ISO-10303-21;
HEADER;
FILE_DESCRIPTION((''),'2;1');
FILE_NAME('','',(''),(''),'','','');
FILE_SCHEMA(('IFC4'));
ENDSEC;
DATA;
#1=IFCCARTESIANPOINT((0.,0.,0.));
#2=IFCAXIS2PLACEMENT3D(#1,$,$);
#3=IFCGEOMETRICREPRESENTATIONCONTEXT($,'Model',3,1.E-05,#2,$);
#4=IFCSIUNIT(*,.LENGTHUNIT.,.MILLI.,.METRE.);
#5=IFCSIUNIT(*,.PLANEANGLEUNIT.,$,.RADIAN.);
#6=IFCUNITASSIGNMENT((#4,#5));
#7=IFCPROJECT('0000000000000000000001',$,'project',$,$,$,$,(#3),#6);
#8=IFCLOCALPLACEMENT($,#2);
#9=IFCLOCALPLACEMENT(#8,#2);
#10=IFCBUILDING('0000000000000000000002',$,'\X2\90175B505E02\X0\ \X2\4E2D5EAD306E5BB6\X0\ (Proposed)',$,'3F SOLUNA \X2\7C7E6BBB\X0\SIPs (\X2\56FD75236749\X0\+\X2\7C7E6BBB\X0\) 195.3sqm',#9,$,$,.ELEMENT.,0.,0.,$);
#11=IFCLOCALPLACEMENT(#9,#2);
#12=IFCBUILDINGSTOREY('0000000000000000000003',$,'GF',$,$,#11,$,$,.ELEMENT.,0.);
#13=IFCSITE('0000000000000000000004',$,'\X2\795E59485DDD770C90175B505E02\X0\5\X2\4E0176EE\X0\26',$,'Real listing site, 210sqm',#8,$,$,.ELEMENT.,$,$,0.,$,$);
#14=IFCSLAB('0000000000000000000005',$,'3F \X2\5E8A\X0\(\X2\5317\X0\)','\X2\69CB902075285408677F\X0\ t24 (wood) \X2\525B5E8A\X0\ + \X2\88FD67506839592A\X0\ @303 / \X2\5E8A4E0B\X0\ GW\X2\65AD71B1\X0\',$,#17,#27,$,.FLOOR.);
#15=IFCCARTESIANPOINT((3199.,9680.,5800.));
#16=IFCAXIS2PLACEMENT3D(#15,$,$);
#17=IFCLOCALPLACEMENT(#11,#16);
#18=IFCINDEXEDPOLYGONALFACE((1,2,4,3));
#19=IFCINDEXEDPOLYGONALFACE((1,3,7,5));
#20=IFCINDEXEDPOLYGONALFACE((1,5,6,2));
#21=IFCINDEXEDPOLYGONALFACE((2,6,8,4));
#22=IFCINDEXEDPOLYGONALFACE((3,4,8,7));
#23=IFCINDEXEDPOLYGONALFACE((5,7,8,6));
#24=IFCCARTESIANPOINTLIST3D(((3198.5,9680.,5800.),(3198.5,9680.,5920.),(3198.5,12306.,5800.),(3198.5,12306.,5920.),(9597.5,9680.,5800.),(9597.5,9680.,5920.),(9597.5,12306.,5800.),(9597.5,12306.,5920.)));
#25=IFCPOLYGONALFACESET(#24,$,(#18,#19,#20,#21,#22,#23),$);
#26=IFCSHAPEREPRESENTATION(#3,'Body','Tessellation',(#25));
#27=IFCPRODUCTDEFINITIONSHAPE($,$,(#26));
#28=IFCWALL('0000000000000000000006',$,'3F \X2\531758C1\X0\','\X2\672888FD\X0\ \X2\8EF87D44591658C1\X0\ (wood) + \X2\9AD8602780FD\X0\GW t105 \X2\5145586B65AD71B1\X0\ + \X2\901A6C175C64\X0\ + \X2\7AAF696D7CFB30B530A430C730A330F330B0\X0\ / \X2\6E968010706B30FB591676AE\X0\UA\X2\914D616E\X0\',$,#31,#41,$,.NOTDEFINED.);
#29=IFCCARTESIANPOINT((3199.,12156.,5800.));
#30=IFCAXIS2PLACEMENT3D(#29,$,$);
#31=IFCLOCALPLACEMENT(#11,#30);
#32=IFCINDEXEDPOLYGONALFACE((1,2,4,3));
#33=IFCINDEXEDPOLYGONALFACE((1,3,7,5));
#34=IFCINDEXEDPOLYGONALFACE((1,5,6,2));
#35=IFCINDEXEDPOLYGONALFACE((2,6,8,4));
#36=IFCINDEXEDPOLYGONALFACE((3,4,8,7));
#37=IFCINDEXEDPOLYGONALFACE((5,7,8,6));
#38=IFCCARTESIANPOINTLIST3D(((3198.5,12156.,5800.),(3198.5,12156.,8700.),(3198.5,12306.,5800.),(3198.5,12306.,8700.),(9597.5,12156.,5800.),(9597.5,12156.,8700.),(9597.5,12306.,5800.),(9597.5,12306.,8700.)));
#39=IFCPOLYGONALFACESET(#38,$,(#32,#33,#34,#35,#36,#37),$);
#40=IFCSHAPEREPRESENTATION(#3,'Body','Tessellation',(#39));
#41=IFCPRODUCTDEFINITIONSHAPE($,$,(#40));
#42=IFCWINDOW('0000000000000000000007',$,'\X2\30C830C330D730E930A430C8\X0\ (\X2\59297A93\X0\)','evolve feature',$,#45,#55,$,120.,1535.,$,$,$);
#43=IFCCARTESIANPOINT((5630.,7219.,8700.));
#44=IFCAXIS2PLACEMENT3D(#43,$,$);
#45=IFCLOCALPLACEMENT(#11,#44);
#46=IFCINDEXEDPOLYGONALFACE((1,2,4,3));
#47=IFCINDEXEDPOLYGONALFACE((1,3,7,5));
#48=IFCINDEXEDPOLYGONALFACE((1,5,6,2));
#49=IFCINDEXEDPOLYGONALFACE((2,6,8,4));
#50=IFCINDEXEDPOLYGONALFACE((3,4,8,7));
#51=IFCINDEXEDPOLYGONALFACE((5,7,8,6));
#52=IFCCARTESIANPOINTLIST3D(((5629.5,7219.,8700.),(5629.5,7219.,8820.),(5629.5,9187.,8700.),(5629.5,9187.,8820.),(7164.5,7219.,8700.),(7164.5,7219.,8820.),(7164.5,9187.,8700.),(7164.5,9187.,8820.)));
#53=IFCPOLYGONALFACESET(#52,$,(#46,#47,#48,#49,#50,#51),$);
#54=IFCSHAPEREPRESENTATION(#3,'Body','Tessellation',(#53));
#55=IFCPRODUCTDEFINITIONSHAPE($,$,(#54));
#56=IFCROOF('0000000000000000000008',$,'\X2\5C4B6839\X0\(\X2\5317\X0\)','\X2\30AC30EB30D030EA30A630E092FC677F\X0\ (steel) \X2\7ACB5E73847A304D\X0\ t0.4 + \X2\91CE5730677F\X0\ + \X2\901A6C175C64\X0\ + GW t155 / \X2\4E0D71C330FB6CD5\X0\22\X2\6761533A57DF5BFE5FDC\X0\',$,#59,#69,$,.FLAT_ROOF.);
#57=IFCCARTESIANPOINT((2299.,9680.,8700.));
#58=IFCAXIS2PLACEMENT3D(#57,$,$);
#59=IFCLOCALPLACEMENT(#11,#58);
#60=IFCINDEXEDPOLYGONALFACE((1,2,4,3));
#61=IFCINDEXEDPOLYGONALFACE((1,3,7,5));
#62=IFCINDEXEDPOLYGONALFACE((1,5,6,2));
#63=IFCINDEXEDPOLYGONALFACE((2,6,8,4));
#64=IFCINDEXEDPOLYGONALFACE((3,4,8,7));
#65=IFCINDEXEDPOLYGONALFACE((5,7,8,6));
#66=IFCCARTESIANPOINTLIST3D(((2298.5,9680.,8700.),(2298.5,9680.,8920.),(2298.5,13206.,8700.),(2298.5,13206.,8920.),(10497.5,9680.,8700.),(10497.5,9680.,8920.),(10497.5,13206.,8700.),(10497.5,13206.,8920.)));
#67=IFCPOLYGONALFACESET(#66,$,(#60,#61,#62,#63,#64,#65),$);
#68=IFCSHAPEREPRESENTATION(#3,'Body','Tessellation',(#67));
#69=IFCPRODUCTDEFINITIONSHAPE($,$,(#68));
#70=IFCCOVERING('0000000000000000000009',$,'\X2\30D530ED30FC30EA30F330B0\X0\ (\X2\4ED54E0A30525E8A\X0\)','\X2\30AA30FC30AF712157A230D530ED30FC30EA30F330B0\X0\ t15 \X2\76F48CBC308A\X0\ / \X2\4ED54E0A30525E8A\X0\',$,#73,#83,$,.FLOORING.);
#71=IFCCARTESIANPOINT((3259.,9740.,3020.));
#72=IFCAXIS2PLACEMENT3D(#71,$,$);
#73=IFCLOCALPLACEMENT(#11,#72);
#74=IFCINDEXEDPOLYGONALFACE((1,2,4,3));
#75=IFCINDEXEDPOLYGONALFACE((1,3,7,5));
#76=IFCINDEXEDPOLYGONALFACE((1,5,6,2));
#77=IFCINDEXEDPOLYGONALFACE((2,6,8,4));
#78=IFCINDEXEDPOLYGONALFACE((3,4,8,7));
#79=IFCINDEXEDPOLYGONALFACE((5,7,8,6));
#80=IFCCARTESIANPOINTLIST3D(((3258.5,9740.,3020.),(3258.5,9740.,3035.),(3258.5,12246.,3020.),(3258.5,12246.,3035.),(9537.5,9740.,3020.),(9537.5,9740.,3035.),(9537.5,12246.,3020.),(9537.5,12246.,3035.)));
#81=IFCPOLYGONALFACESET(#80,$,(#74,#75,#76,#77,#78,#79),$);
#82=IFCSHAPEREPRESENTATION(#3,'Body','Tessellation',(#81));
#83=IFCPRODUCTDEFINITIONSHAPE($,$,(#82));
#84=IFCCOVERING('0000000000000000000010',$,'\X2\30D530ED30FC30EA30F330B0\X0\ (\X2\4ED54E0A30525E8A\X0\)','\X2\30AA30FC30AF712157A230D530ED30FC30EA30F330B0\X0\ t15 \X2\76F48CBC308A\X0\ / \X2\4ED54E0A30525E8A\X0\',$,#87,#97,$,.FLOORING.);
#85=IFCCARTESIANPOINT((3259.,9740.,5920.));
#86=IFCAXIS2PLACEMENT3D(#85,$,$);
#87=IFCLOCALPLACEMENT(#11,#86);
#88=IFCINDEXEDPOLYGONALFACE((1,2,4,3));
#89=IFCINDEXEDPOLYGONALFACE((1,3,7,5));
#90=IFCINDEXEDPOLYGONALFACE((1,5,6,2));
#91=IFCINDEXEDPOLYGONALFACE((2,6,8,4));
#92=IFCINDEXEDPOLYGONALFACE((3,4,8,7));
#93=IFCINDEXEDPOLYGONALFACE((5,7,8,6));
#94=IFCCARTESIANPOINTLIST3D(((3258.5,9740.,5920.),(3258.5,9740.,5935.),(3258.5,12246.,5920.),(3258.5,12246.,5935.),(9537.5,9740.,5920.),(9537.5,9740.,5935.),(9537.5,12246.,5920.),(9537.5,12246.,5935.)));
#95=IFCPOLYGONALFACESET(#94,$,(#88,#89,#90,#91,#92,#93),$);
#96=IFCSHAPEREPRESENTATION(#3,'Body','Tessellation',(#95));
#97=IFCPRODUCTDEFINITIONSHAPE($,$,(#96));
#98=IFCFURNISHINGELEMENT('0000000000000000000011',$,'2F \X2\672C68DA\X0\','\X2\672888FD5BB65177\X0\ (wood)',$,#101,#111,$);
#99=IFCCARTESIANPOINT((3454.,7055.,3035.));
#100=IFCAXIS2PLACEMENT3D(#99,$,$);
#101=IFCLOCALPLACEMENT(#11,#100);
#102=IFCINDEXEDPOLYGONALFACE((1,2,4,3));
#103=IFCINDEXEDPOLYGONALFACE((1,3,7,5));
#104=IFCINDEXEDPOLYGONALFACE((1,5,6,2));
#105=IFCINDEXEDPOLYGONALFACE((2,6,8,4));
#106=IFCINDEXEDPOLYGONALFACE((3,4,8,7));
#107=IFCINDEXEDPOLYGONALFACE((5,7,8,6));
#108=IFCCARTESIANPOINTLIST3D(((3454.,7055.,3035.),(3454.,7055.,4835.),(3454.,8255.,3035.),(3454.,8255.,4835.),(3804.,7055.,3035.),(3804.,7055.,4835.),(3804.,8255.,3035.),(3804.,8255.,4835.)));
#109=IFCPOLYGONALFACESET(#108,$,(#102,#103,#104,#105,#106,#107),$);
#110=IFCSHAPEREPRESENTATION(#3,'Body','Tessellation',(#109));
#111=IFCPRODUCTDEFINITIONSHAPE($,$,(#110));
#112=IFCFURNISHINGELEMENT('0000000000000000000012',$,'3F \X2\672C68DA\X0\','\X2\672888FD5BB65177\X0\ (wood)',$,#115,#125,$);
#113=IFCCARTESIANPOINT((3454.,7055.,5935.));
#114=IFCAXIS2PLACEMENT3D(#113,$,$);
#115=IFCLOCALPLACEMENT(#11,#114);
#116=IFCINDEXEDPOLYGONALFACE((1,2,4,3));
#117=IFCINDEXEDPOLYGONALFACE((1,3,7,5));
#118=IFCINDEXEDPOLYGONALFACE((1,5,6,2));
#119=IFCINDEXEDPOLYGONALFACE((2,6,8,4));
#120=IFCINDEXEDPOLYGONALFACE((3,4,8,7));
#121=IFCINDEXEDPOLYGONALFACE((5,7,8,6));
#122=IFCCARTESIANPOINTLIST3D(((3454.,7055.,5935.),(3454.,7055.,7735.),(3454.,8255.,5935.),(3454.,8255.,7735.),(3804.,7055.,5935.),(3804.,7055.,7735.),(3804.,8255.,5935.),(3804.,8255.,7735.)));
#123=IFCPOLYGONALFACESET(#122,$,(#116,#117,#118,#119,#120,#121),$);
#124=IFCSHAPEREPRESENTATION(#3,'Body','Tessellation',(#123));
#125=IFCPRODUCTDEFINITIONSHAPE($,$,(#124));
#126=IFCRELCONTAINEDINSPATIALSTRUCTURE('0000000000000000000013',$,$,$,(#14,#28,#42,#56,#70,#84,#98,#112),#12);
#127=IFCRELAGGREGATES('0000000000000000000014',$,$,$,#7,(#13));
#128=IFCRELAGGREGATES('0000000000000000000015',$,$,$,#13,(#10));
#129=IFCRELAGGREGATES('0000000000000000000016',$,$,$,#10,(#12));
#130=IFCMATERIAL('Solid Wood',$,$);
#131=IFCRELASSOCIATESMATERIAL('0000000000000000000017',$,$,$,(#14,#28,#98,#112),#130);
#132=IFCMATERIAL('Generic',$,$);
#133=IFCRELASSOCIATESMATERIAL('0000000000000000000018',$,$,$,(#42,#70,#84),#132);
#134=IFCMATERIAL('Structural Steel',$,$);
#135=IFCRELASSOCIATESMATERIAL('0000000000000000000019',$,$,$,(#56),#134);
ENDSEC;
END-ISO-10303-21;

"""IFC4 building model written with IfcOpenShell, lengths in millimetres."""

from ifc_helpers import new_model, si_unit, frame, frame_2d, origin, place, context, project, spatial, rectangle, extrude, material, element, save


model = new_model("IFC4")

# Units and contexts
model_context = context("Model", 3, precision=1e-05, world=origin())
ifc_project = project(units=[si_unit("LENGTHUNIT", "METRE", prefix="MILLI"), si_unit("PLANEANGLEUNIT", "RADIAN")], contexts=[model_context])

# Site, building, storey
site_placement = place(None, origin())
site = spatial("IfcSite", under=ifc_project, at=site_placement, Name="神奈川県逗子市5丁目26", ObjectType="Real listing site, 210sqm", CompositionType="ELEMENT", RefElevation=0.0)
building_placement = place(site_placement, origin())
building = spatial("IfcBuilding", under=site, at=building_placement, Name="逗子市 中庭の家 (Proposed)", ObjectType="3F SOLUNA 籾殻SIPs (国産杉+籾殻) 195.3sqm", CompositionType="ELEMENT", ElevationOfRefHeight=0.0, ElevationOfTerrain=0.0)
storey_placement = place(building_placement, origin())
storey = spatial("IfcBuildingStorey", under=building, at=storey_placement, Name="GF", CompositionType="ELEMENT", Elevation=0.0)

# Slab
ifc_material_1 = material(Name="Solid Wood")
slab_placement = place(storey_placement, frame((3199.0, 9680.0, 5800.0)))
element("IfcSlab", 1, at=slab_placement, inside=storey, material=ifc_material_1, Name="3F 床(北)", Description="構造用合板 t24 (wood) 剛床 + 製材根太 @303 / 床下 GW断熱", PredefinedType="FLOOR", context=model_context, shape_type="SweptSolid", body=[
    extrude(rectangle(XDim=6399.0, YDim=2626.0, at=frame_2d((3199.0, 1313.0))), frame((3199.0, 9680.0, 5800.0)), (0.0, 0.0, 1.0), 120.0),
])

# Wall
wall_1_placement = place(storey_placement, frame((3199.0, 12156.0, 5800.0)))
element("IfcWall", 2, at=wall_1_placement, inside=storey, material=ifc_material_1, Name="3F 北壁", Description="木製 軸組外壁 (wood) + 高性能GW t105 充填断熱 + 通気層 + 窯業系サイディング / 準耐火・外皮UA配慮", PredefinedType="NOTDEFINED", context=model_context, shape_type="SweptSolid", body=[
    extrude(rectangle(XDim=6399.0, YDim=150.0, at=frame_2d((3199.0, 75.0))), frame((3199.0, 12156.0, 5800.0)), (0.0, 0.0, 1.0), 2900.0),
])

# Window
ifc_material_2 = material(Name="Generic")
window_1_placement = place(storey_placement, frame((5630.0, 7219.0, 8700.0)))
element("IfcWindow", 3, at=window_1_placement, inside=storey, material=ifc_material_2, Name="トップライト (天窓)", Description="evolve feature", OverallHeight=120.0, OverallWidth=1535.0, context=model_context, shape_type="SweptSolid", body=[
    extrude(rectangle(XDim=1535.0, YDim=1968.0, at=frame_2d((767.0, 984.0))), frame((5630.0, 7219.0, 8700.0)), (0.0, 0.0, 1.0), 120.0),
])

# Roof
ifc_material_3 = material(Name="Structural Steel")
roof_1_placement = place(storey_placement, frame((2299.0, 9680.0, 8700.0)))
element("IfcRoof", 4, at=roof_1_placement, inside=storey, material=ifc_material_3, Name="屋根(北)", Description="ガルバリウム鋼板 (steel) 立平葺き t0.4 + 野地板 + 通気層 + GW t155 / 不燃・法22条区域対応", PredefinedType="FLAT_ROOF", context=model_context, shape_type="SweptSolid", body=[
    extrude(rectangle(XDim=8199.0, YDim=3526.0, at=frame_2d((4099.0, 1763.0))), frame((2299.0, 9680.0, 8700.0)), (0.0, 0.0, 1.0), 220.0),
])

# Coverings
covering_1_placement = place(storey_placement, frame((3259.0, 9740.0, 3020.0)))
element("IfcCovering", 5, at=covering_1_placement, inside=storey, material=ifc_material_2, Name="フローリング (仕上げ床)", Description="オーク無垢フローリング t15 直貼り / 仕上げ床", PredefinedType="FLOORING", context=model_context, shape_type="SweptSolid", body=[
    extrude(rectangle(XDim=6279.0, YDim=2506.0, at=frame_2d((3139.0, 1253.0))), frame((3259.0, 9740.0, 3020.0)), (0.0, 0.0, 1.0), 15.0),
])
covering_2_placement = place(storey_placement, frame((3259.0, 9740.0, 5920.0)))
element("IfcCovering", 6, at=covering_2_placement, inside=storey, material=ifc_material_2, Name="フローリング (仕上げ床)", Description="オーク無垢フローリング t15 直貼り / 仕上げ床", PredefinedType="FLOORING", context=model_context, shape_type="SweptSolid", body=[
    extrude(rectangle(XDim=6279.0, YDim=2506.0, at=frame_2d((3139.0, 1253.0))), frame((3259.0, 9740.0, 5920.0)), (0.0, 0.0, 1.0), 15.0),
])

# Furnishing elements
furnishing_1_placement = place(storey_placement, frame((3454.0, 7055.0, 3035.0)))
element("IfcFurnishingElement", 7, at=furnishing_1_placement, inside=storey, material=ifc_material_1, Name="2F 本棚", Description="木製家具 (wood)", context=model_context, shape_type="SweptSolid", body=[
    extrude(rectangle(XDim=350.0, YDim=1200.0, at=frame_2d((175.0, 600.0))), frame((3454.0, 7055.0, 3035.0)), (0.0, 0.0, 1.0), 1800.0),
])
furnishing_2_placement = place(storey_placement, frame((3454.0, 7055.0, 5935.0)))
element("IfcFurnishingElement", 8, at=furnishing_2_placement, inside=storey, material=ifc_material_1, Name="3F 本棚", Description="木製家具 (wood)", context=model_context, shape_type="SweptSolid", body=[
    extrude(rectangle(XDim=350.0, YDim=1200.0, at=frame_2d((175.0, 600.0))), frame((3454.0, 7055.0, 5935.0)), (0.0, 0.0, 1.0), 1800.0),
])

save(model, "model.ifc")
